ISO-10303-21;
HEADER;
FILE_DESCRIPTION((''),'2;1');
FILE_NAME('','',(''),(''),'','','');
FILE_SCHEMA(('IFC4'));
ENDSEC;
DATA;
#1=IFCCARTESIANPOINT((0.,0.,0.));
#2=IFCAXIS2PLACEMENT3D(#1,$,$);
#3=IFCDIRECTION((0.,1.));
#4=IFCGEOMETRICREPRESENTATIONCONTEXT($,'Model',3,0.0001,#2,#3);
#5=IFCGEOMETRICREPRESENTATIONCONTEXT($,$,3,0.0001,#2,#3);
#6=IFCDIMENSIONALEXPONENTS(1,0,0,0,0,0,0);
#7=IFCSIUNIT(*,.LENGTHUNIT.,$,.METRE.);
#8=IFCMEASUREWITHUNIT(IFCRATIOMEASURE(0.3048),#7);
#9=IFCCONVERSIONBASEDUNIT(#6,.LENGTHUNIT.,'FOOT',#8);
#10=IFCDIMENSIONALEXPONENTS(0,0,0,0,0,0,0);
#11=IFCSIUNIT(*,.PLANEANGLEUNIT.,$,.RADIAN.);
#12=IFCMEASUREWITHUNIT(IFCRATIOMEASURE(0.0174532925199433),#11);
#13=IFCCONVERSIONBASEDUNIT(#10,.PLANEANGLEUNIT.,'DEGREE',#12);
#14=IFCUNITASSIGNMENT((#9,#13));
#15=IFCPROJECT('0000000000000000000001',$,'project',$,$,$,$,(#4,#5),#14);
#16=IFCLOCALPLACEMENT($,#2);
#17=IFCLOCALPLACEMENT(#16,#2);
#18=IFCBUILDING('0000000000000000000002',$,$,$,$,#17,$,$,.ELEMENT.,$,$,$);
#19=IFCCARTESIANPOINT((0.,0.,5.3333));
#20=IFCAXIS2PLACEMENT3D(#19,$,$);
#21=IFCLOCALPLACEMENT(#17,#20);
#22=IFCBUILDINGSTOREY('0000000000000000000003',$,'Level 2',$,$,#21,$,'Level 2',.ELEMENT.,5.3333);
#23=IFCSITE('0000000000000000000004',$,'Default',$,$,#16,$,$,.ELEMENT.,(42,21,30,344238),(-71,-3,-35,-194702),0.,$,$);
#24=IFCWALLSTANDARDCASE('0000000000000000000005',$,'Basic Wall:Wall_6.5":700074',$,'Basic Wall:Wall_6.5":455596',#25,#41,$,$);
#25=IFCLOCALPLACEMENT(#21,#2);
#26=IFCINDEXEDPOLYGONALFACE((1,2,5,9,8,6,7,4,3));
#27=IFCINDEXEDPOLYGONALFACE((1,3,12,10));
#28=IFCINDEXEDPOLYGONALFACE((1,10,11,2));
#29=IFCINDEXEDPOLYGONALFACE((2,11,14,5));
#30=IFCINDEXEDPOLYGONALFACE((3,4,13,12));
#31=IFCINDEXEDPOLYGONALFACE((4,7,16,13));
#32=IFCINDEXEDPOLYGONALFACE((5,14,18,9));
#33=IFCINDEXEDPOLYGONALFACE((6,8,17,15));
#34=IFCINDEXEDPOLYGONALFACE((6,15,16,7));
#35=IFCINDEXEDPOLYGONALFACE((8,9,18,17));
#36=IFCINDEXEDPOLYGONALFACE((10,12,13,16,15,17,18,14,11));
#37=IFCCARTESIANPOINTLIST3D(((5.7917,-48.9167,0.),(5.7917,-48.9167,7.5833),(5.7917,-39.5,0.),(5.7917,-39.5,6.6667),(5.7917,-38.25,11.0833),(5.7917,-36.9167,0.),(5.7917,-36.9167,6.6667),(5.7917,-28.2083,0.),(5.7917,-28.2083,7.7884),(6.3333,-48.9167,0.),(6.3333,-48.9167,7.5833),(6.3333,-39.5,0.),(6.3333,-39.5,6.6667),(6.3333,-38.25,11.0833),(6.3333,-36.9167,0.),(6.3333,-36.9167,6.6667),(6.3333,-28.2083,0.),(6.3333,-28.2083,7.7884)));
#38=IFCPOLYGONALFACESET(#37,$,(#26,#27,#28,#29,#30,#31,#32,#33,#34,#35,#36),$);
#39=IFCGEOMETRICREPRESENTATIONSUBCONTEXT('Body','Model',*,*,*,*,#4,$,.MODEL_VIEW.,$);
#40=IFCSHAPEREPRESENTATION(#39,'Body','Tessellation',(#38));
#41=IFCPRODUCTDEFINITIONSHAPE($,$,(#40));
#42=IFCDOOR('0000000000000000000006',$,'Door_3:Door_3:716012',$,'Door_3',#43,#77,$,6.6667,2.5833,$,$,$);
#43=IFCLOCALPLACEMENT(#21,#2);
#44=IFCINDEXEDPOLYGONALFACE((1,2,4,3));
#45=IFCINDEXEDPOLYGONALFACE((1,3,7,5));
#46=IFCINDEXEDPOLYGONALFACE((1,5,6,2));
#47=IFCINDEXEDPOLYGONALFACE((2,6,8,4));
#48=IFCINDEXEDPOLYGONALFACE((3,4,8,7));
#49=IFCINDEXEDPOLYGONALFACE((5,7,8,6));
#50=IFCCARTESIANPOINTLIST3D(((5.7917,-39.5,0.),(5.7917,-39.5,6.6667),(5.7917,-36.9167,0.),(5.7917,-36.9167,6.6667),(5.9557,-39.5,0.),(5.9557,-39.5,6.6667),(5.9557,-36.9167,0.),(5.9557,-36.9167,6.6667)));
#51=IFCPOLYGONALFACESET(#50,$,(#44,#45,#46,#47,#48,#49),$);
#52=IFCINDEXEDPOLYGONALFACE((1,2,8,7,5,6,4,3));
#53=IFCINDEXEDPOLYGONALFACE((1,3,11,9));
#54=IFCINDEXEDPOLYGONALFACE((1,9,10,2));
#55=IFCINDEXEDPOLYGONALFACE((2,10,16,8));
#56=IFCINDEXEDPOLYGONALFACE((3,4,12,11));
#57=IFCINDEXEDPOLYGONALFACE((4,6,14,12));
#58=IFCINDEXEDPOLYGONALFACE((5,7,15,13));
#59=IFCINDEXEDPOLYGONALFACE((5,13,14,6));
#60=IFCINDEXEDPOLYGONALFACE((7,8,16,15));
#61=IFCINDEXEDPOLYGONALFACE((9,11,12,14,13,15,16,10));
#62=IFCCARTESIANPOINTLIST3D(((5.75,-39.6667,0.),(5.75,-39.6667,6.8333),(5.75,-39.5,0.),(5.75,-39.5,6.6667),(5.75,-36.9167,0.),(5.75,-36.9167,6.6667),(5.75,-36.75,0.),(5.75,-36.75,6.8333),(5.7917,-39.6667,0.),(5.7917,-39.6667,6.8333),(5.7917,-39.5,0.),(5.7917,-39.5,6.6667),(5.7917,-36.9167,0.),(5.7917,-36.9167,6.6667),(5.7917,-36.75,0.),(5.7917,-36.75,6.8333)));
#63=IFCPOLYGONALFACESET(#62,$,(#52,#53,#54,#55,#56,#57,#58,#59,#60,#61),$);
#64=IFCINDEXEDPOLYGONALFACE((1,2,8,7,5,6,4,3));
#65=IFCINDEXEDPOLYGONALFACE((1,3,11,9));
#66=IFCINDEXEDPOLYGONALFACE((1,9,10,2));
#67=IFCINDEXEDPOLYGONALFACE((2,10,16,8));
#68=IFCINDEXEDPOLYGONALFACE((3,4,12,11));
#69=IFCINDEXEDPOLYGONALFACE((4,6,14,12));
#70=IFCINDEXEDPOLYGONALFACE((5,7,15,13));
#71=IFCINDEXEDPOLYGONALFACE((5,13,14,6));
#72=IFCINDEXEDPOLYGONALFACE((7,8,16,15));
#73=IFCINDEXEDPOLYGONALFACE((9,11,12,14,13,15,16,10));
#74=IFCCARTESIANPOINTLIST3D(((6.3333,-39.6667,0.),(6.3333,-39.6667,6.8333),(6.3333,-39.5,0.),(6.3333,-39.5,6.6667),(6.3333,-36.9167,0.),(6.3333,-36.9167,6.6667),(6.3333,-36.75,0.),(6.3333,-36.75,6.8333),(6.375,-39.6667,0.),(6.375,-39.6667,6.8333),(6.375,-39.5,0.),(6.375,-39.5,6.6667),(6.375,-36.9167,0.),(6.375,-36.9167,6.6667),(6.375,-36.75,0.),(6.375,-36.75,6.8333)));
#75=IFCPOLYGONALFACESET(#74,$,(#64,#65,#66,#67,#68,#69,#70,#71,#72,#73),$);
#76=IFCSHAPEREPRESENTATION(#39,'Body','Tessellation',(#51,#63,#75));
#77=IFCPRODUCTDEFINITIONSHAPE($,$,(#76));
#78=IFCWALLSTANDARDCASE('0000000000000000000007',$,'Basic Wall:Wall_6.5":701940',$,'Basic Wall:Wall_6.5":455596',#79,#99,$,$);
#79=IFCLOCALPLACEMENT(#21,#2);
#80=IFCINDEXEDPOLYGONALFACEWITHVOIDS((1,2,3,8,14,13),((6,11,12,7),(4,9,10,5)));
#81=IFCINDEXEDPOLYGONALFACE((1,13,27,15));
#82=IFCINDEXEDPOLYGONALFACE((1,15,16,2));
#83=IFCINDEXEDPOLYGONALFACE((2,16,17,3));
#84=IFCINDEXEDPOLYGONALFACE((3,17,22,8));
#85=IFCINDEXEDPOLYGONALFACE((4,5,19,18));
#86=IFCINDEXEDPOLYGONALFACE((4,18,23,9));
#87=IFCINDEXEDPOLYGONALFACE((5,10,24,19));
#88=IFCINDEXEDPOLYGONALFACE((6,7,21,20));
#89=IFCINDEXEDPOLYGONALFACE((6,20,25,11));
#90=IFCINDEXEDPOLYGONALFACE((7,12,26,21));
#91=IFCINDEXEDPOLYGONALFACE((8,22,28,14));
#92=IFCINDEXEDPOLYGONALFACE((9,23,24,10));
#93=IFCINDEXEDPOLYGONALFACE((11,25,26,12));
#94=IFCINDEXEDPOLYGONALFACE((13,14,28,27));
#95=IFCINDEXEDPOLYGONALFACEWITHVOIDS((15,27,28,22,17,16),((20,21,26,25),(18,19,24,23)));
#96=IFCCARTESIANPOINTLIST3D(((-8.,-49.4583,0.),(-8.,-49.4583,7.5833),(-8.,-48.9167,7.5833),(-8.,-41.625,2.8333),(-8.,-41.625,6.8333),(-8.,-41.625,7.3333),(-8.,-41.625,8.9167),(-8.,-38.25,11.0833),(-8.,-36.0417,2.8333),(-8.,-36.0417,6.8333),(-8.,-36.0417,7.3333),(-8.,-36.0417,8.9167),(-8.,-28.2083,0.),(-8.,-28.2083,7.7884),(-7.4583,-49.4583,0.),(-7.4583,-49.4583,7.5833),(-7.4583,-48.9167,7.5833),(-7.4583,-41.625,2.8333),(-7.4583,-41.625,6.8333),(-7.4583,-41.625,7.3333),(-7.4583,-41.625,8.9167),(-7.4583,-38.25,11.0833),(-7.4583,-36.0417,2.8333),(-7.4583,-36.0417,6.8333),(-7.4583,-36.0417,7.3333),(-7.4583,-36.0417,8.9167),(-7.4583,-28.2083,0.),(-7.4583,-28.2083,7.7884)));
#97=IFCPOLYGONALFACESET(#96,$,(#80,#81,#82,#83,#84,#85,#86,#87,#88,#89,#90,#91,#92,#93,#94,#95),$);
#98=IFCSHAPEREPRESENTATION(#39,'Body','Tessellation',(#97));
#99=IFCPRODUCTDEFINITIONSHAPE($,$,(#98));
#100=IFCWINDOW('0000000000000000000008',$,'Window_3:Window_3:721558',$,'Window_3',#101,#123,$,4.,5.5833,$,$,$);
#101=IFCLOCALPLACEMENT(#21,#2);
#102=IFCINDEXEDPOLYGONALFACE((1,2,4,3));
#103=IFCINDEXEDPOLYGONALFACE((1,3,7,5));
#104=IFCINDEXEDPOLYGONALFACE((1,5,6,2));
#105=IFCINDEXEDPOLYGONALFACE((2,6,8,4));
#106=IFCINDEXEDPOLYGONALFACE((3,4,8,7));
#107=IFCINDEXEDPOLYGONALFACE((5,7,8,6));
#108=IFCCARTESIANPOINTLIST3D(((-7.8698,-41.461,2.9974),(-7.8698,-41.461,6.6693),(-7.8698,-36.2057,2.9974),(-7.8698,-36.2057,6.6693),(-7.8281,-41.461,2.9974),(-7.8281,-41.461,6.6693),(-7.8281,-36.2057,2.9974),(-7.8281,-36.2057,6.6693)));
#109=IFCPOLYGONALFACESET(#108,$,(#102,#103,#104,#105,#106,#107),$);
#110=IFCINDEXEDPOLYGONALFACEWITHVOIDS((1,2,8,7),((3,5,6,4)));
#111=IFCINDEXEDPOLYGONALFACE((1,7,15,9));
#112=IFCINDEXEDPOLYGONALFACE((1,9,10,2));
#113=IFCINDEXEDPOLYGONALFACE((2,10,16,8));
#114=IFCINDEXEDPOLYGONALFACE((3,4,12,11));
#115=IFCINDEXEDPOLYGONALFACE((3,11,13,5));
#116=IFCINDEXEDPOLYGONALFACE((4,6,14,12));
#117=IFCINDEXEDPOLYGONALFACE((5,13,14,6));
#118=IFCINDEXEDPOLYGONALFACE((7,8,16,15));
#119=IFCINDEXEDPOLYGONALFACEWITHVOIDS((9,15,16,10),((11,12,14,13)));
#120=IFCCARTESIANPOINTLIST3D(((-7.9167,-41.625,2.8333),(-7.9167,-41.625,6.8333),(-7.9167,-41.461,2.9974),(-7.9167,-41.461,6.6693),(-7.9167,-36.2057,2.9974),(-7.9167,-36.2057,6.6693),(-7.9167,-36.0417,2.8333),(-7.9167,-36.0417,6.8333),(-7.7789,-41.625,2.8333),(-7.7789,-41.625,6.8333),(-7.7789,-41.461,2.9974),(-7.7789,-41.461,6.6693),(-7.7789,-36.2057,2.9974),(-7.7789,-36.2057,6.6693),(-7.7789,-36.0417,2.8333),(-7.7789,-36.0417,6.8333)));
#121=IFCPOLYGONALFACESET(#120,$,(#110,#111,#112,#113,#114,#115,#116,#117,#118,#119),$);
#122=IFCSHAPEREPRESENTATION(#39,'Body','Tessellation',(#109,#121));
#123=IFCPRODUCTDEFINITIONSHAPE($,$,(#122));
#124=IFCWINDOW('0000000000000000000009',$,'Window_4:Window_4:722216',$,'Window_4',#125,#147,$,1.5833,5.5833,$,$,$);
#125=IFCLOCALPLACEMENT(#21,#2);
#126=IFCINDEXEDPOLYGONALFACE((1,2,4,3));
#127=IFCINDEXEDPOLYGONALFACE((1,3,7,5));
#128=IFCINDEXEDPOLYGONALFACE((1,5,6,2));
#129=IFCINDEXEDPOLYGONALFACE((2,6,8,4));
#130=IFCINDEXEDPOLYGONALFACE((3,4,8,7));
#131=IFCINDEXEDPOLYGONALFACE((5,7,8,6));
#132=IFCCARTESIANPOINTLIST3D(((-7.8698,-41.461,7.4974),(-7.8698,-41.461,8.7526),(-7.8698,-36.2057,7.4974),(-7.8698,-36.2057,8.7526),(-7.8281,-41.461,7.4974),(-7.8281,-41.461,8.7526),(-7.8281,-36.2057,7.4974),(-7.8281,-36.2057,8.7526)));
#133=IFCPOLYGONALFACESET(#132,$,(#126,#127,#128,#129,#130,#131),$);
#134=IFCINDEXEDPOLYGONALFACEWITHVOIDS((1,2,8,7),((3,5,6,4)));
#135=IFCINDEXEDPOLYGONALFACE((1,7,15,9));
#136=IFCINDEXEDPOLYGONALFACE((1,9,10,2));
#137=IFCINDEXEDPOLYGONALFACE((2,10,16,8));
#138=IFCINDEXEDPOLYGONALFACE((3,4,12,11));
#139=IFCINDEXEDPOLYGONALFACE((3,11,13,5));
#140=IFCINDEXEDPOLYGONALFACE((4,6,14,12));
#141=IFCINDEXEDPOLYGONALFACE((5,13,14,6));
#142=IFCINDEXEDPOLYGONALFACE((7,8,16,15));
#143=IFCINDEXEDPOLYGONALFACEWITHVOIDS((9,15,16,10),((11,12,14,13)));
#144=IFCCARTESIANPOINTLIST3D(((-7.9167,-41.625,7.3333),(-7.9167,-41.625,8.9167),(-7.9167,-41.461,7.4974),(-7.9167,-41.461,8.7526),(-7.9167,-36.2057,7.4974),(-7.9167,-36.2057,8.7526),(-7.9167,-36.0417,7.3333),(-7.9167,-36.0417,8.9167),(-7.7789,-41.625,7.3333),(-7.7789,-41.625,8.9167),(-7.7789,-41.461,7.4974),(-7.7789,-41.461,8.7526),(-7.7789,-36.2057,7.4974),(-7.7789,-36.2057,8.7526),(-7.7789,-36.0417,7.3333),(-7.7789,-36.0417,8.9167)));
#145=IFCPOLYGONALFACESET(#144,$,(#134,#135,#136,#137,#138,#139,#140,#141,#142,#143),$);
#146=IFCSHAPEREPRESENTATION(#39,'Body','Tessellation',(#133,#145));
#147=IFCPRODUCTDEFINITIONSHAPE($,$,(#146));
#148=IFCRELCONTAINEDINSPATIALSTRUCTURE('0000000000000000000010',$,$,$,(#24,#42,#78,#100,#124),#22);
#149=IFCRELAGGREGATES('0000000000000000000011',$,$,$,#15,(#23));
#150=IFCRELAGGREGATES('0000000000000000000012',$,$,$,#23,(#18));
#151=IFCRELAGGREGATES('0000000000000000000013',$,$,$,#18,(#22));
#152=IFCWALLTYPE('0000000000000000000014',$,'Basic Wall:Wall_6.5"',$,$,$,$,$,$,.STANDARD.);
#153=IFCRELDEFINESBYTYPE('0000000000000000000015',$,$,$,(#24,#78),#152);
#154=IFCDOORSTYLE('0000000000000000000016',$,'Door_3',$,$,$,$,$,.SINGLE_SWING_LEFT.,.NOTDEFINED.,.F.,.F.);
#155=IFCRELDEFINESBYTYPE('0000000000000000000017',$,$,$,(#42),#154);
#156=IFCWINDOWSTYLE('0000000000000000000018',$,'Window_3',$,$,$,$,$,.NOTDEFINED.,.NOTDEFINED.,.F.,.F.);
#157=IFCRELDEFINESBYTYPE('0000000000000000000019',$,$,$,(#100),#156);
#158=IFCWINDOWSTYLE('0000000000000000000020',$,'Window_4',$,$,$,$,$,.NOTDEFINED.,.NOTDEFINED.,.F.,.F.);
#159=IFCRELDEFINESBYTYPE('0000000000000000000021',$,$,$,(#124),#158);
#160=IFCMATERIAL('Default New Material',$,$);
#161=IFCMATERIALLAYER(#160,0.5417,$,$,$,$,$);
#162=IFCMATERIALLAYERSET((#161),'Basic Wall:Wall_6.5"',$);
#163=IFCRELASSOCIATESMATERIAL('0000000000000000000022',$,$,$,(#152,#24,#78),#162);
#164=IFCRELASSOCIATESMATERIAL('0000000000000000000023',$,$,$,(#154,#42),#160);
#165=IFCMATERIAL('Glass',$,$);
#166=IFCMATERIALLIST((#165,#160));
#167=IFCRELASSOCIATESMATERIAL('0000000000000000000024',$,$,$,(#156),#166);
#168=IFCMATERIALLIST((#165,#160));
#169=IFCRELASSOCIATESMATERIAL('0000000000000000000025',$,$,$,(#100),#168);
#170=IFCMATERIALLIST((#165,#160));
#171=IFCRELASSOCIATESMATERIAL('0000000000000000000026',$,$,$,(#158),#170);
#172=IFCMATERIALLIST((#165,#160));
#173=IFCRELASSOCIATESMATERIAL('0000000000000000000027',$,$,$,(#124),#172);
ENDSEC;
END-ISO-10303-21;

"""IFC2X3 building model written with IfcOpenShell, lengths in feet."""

from ifc_helpers import new_model, entity, si_unit, converted_unit, direction, frame, frame_2d, origin, origin_2d_with_axis, place, context, subcontext, project, spatial, polyline, rectangle, outline, extrude, clip, bounded_halfspace, source, transform, mapped, material, material_list, layer, layer_set, layer_usage, type_object, type_shapes, element, fill, save


model = new_model("IFC2X3")

# Units and contexts
model_context = context("Model", 3, precision=0.0001, world=origin(), true_north=direction((0.0, 1.0)))
context_of_model = context(None, 3, precision=0.0001, world=origin(), true_north=direction((0.0, 1.0)))
body_context = subcontext(model_context, "Body", "Model", "MODEL_VIEW")
ifc_project = project(units=[converted_unit("LENGTHUNIT", "FOOT", entity("IfcRatioMeasure", 0.3048), si_unit("LENGTHUNIT", "METRE"), dimensions=[1, 0, 0, 0, 0, 0, 0]), converted_unit("PLANEANGLEUNIT", "DEGREE", entity("IfcRatioMeasure", 0.0174532925199433), si_unit("PLANEANGLEUNIT", "RADIAN"), dimensions=[0, 0, 0, 0, 0, 0, 0])], contexts=[model_context, context_of_model])

# Site, building, storey
site_placement = place(None, origin())
site = spatial("IfcSite", under=ifc_project, at=site_placement, Name="Default", CompositionType="ELEMENT", RefLatitude=(42, 21, 30, 344238), RefLongitude=(-71, -3, -35, -194702), RefElevation=0.0)
building_placement = place(site_placement, origin())
building = spatial("IfcBuilding", under=site, at=building_placement, CompositionType="ELEMENT")
storey_placement = place(building_placement, frame((0.0, 0.0, 5.3333)))
storey = spatial("IfcBuildingStorey", under=building, at=storey_placement, Name="Level 2", LongName="Level 2", CompositionType="ELEMENT", Elevation=5.3333)

# Shared definitions
ifc_material_1 = material(Name="Default New Material")

# Wall, opening, door
ifc_layer_1 = layer(ifc_material_1, 0.5417)
ifc_layer_set_1 = layer_set([ifc_layer_1], Name="Basic Wall:Wall_6.5\"")
ifc_layer_usage_1 = layer_usage(ifc_layer_set_1, "AXIS2", "POSITIVE", -0.2708)
wall_type_1 = type_object("IfcWallType", Name="Basic Wall:Wall_6.5\"", PredefinedType="STANDARD", material=ifc_layer_set_1)
wall_1_placement = place(storey_placement, frame((6.0625, -28.2083, 0.0), z_axis=(0.0, 0.0, 1.0), x_axis=(0.0, -1.0, 0.0)))
wall_1 = element("IfcWallStandardCase", 1, at=wall_1_placement, inside=storey, type_object=wall_type_1, material=ifc_layer_usage_1, Name="Basic Wall:Wall_6.5\":700074", ObjectType="Basic Wall:Wall_6.5\":455596", context=body_context, shape_type="Clipping", body=[
    clip(clip(extrude(rectangle(XDim=20.7083, YDim=0.5417, at=frame_2d((10.3542, 0.0), x_axis=(-1.0, 0.0))), origin(), (0.0, 0.0, 1.0), 11.0833), bounded_halfspace(frame((10.0417, -0.2708, 11.0833), z_axis=(-0.31177, 0.0, -0.950157), x_axis=(0.0, 1.0, 0.0)), True, frame((10.0417, -0.2708, 11.0833)), polyline([(0.0, 0.0), (10.6667, 0.0), (10.6667, 0.5417), (0.0, 0.5417), (0.0, 0.0)]))), bounded_halfspace(frame((0.0, -0.2708, 7.7884), z_axis=(0.31177, 0.0, -0.950157), x_axis=(0.0, 1.0, 0.0)), True, frame((0.0, -0.2708, 7.7884)), polyline([(0.0, 0.0), (10.0417, 0.0), (10.0417, 0.5417), (0.0, 0.5417), (0.0, 0.0)]))),
])
opening_1_placement = place(wall_1_placement, frame((11.2917, 0.2708, 0.0)))
opening_1 = element("IfcOpeningElement", 2, at=opening_1_placement, cuts=wall_1, ObjectType="Opening", context=body_context, shape_type="SweptSolid", body=[
    extrude(rectangle(XDim=2.5833, YDim=6.6667, at=frame_2d((3.3333, 1.2917), x_axis=(0.0, -1.0))), frame((0.0, 0.0, 0.0), z_axis=(0.0, -1.0, 0.0), x_axis=(0.0, 0.0, 1.0)), (0.0, 0.0, 1.0), 0.5417),
])
door_style_1 = type_object("IfcDoorStyle", Name="Door_3", ConstructionType="NOTDEFINED", OperationType="SINGLE_SWING_LEFT", ParameterTakesPrecedence=False, Sizeable=False, material=ifc_material_1)
shared_shape_1 = source(origin(), body_context, "Body", "SweptSolid", [
    extrude(rectangle(XDim=2.5833, YDim=0.164, at=origin_2d_with_axis()), frame((1.2917, 0.4596, 0.0)), (0.0, 0.0, 1.0), 6.6667),
    extrude(outline(polyline([(-1.4583, -3.4583), (1.4583, -3.4583), (1.4583, 3.375), (1.2917, 3.375), (1.2917, -3.2917), (-1.2917, -3.2917), (-1.2917, 3.375), (-1.4583, 3.375), (-1.4583, -3.4583)])), frame((1.2917, 0.5833, 3.375), z_axis=(0.0, -1.0, 0.0), x_axis=(-1.0, 0.0, 0.0)), (0.0, 0.0, 1.0), 0.0417),
    extrude(outline(polyline([(-3.4583, -1.4583), (3.375, -1.4583), (3.375, -1.2917), (-3.2917, -1.2917), (-3.2917, 1.2917), (3.375, 1.2917), (3.375, 1.4583), (-3.4583, 1.4583), (-3.4583, -1.4583)])), frame((1.2917, 0.0, 3.375), z_axis=(0.0, -1.0, 0.0), x_axis=(0.0, 0.0, -1.0)), (0.0, 0.0, 1.0), 0.0417),
])
type_shapes(door_style_1, [shared_shape_1])
door_1_placement = place(opening_1_placement, frame((0.0, 0.0, 0.0), z_axis=(0.0, 0.0, 1.0), x_axis=(-1.0, 0.0, 0.0)))
door_1 = element("IfcDoor", 3, at=door_1_placement, inside=storey, type_object=door_style_1, material=ifc_material_1, Name="Door_3:Door_3:716012", ObjectType="Door_3", OverallHeight=6.6667, OverallWidth=2.5833, context=body_context, shape_type="MappedRepresentation", body=[
    mapped(shared_shape_1, transform((0.0, 0.0, 0.0), scale=1.0)),
])
fill(opening_1, door_1)

# Wall, openings, windows
ifc_layer_usage_2 = layer_usage(ifc_layer_set_1, "AXIS2", "NEGATIVE", 0.2708)
wall_2_placement = place(storey_placement, frame((-7.7292, -28.2083, 0.0), z_axis=(0.0, 0.0, 1.0), x_axis=(0.0, -1.0, 0.0)))
wall_2 = element("IfcWallStandardCase", 4, at=wall_2_placement, inside=storey, type_object=wall_type_1, material=ifc_layer_usage_2, Name="Basic Wall:Wall_6.5\":701940", ObjectType="Basic Wall:Wall_6.5\":455596", context=body_context, shape_type="Clipping", body=[
    clip(clip(clip(clip(clip(extrude(rectangle(XDim=21.25, YDim=0.5417, at=frame_2d((10.625, 0.0), x_axis=(-1.0, 0.0))), origin(), (0.0, 0.0, 1.0), 11.0833), bounded_halfspace(frame((10.0417, -0.2708, 11.0833), z_axis=(-0.31177, 0.0, -0.950157), x_axis=(0.0, 1.0, 0.0)), True, frame((10.0417, -0.2708, 11.0833)), polyline([(0.0, 0.0), (10.6667, 0.0), (10.6667, 0.5417), (4.0, 0.5417), (3.625, 0.5417), (0.0, 0.5417), (0.0, 0.0)]))), bounded_halfspace(frame((20.7083, -0.2708, 7.5833), z_axis=(0.0, 0.0, -1.0), x_axis=(0.0, 1.0, 0.0)), True, frame((20.7083, -0.2708, 7.5833)), polyline([(0.0, 0.0), (0.375, 0.0), (0.375, 0.5417), (0.0, 0.5417), (0.0, 0.0)]))), bounded_halfspace(frame((0.0, -0.2708, 7.7884), z_axis=(0.31177, 0.0, -0.950157), x_axis=(0.0, 1.0, 0.0)), True, frame((0.0, -0.2708, 7.7884)), polyline([(0.0, 0.0), (10.0417, 0.0), (10.0417, 0.5417), (0.0, 0.5417), (0.0, 0.0)]))), bounded_halfspace(frame((21.25, -0.2708, 7.5833), z_axis=(0.0, 0.0, 1.0), x_axis=(0.0, 1.0, 0.0)), False, frame((21.25, -0.2708, 7.5833)), polyline([(0.0, 0.0), (0.0, 0.5417), (-0.1667, 0.5417), (-0.1667, 0.0), (0.0, 0.0)]))), bounded_halfspace(frame((20.7083, -0.2708, 7.5833), z_axis=(0.0, 0.0, -1.0), x_axis=(0.0, 1.0, 0.0)), True, frame((20.7083, -0.2708, 7.5833)), polyline([(0.0, 0.0), (0.375, 0.0), (0.375, 0.5417), (0.0, 0.5417), (0.0, 0.0)]))),
])
opening_2_placement = place(wall_2_placement, frame((13.4167, 0.2708, 2.8333)))
opening_2 = element("IfcOpeningElement", 5, at=opening_2_placement, cuts=wall_2, ObjectType="Opening", context=body_context, shape_type="SweptSolid", body=[
    extrude(rectangle(XDim=4.0, YDim=5.5833, at=frame_2d((2.0, 2.7917), x_axis=(-1.0, 0.0))), frame((0.0, 0.0, 0.0), z_axis=(0.0, -1.0, 0.0), x_axis=(0.0, 0.0, 1.0)), (0.0, 0.0, 1.0), 0.5417),
])
opening_3_placement = place(wall_2_placement, frame((13.4167, 0.2708, 7.3333)))
opening_3 = element("IfcOpeningElement", 6, at=opening_3_placement, cuts=wall_2, ObjectType="Opening", context=body_context, shape_type="SweptSolid", body=[
    extrude(rectangle(XDim=1.5833, YDim=5.5833, at=frame_2d((0.7917, 2.7917), x_axis=(-1.0, 0.0))), frame((0.0, 0.0, 0.0), z_axis=(0.0, -1.0, 0.0), x_axis=(0.0, 0.0, 1.0)), (0.0, 0.0, 1.0), 0.5417),
])
ifc_material_2 = material(Name="Glass")
ifc_material_list_1 = material_list([ifc_material_2, ifc_material_1])
ifc_material_list_2 = material_list([ifc_material_2, ifc_material_1])
window_style_1 = type_object("IfcWindowStyle", Name="Window_3", ConstructionType="NOTDEFINED", OperationType="NOTDEFINED", ParameterTakesPrecedence=False, Sizeable=False, material=ifc_material_list_2)
shared_shape_2 = source(origin(), body_context, "Body", "SweptSolid", [
    extrude(rectangle(XDim=0.0417, YDim=5.2552, at=origin_2d_with_axis()), frame((2.7917, 0.3906, 0.164), z_axis=(0.0, 0.0, 1.0), x_axis=(0.0, 1.0, 0.0)), (0.0, 0.0, 1.0), 3.6719),
    extrude(outline(polyline([(-2.7917, -2.0), (2.7917, -2.0), (2.7917, 2.0), (-2.7917, 2.0), (-2.7917, -2.0)]), holes=[polyline([(-2.6276, -1.836), (-2.6276, 1.836), (2.6276, 1.836), (2.6276, -1.836), (-2.6276, -1.836)])]), frame((2.7917, 0.3205, 2.0), z_axis=(0.0, 1.0, 0.0), x_axis=(1.0, 0.0, 0.0)), (0.0, 0.0, 1.0), 0.1378),
])
type_shapes(window_style_1, [shared_shape_2])
window_1_placement = place(opening_2_placement, frame((0.0, 0.0, 0.0), z_axis=(0.0, 0.0, 1.0), x_axis=(-1.0, 0.0, 0.0)))
window_1 = element("IfcWindow", 7, at=window_1_placement, inside=storey, type_object=window_style_1, material=ifc_material_list_1, Name="Window_3:Window_3:721558", ObjectType="Window_3", OverallHeight=4.0, OverallWidth=5.5833, context=body_context, shape_type="MappedRepresentation", body=[
    mapped(shared_shape_2, transform((0.0, 0.0, 0.0), scale=1.0)),
])
fill(opening_2, window_1)
ifc_material_list_3 = material_list([ifc_material_2, ifc_material_1])
ifc_material_list_4 = material_list([ifc_material_2, ifc_material_1])
window_style_2 = type_object("IfcWindowStyle", Name="Window_4", ConstructionType="NOTDEFINED", OperationType="NOTDEFINED", ParameterTakesPrecedence=False, Sizeable=False, material=ifc_material_list_4)
shared_shape_3 = source(origin(), body_context, "Body", "SweptSolid", [
    extrude(rectangle(XDim=0.0417, YDim=5.2552, at=origin_2d_with_axis()), frame((2.7917, 0.3906, 0.164), z_axis=(0.0, 0.0, 1.0), x_axis=(0.0, 1.0, 0.0)), (0.0, 0.0, 1.0), 1.2552),
    extrude(outline(polyline([(-2.7917, -0.7917), (2.7917, -0.7917), (2.7917, 0.7917), (-2.7917, 0.7917), (-2.7917, -0.7917)]), holes=[polyline([(-2.6276, -0.6276), (-2.6276, 0.6276), (2.6276, 0.6276), (2.6276, -0.6276), (-2.6276, -0.6276)])]), frame((2.7917, 0.3205, 0.7917), z_axis=(0.0, 1.0, 0.0), x_axis=(1.0, 0.0, 0.0)), (0.0, 0.0, 1.0), 0.1378),
])
type_shapes(window_style_2, [shared_shape_3])
window_2_placement = place(opening_3_placement, frame((0.0, 0.0, 0.0), z_axis=(0.0, 0.0, 1.0), x_axis=(-1.0, 0.0, 0.0)))
window_2 = element("IfcWindow", 8, at=window_2_placement, inside=storey, type_object=window_style_2, material=ifc_material_list_3, Name="Window_4:Window_4:722216", ObjectType="Window_4", OverallHeight=1.5833, OverallWidth=5.5833, context=body_context, shape_type="MappedRepresentation", body=[
    mapped(shared_shape_3, transform((0.0, 0.0, 0.0), scale=1.0)),
])
fill(opening_3, window_2)

save(model, "model.ifc")
